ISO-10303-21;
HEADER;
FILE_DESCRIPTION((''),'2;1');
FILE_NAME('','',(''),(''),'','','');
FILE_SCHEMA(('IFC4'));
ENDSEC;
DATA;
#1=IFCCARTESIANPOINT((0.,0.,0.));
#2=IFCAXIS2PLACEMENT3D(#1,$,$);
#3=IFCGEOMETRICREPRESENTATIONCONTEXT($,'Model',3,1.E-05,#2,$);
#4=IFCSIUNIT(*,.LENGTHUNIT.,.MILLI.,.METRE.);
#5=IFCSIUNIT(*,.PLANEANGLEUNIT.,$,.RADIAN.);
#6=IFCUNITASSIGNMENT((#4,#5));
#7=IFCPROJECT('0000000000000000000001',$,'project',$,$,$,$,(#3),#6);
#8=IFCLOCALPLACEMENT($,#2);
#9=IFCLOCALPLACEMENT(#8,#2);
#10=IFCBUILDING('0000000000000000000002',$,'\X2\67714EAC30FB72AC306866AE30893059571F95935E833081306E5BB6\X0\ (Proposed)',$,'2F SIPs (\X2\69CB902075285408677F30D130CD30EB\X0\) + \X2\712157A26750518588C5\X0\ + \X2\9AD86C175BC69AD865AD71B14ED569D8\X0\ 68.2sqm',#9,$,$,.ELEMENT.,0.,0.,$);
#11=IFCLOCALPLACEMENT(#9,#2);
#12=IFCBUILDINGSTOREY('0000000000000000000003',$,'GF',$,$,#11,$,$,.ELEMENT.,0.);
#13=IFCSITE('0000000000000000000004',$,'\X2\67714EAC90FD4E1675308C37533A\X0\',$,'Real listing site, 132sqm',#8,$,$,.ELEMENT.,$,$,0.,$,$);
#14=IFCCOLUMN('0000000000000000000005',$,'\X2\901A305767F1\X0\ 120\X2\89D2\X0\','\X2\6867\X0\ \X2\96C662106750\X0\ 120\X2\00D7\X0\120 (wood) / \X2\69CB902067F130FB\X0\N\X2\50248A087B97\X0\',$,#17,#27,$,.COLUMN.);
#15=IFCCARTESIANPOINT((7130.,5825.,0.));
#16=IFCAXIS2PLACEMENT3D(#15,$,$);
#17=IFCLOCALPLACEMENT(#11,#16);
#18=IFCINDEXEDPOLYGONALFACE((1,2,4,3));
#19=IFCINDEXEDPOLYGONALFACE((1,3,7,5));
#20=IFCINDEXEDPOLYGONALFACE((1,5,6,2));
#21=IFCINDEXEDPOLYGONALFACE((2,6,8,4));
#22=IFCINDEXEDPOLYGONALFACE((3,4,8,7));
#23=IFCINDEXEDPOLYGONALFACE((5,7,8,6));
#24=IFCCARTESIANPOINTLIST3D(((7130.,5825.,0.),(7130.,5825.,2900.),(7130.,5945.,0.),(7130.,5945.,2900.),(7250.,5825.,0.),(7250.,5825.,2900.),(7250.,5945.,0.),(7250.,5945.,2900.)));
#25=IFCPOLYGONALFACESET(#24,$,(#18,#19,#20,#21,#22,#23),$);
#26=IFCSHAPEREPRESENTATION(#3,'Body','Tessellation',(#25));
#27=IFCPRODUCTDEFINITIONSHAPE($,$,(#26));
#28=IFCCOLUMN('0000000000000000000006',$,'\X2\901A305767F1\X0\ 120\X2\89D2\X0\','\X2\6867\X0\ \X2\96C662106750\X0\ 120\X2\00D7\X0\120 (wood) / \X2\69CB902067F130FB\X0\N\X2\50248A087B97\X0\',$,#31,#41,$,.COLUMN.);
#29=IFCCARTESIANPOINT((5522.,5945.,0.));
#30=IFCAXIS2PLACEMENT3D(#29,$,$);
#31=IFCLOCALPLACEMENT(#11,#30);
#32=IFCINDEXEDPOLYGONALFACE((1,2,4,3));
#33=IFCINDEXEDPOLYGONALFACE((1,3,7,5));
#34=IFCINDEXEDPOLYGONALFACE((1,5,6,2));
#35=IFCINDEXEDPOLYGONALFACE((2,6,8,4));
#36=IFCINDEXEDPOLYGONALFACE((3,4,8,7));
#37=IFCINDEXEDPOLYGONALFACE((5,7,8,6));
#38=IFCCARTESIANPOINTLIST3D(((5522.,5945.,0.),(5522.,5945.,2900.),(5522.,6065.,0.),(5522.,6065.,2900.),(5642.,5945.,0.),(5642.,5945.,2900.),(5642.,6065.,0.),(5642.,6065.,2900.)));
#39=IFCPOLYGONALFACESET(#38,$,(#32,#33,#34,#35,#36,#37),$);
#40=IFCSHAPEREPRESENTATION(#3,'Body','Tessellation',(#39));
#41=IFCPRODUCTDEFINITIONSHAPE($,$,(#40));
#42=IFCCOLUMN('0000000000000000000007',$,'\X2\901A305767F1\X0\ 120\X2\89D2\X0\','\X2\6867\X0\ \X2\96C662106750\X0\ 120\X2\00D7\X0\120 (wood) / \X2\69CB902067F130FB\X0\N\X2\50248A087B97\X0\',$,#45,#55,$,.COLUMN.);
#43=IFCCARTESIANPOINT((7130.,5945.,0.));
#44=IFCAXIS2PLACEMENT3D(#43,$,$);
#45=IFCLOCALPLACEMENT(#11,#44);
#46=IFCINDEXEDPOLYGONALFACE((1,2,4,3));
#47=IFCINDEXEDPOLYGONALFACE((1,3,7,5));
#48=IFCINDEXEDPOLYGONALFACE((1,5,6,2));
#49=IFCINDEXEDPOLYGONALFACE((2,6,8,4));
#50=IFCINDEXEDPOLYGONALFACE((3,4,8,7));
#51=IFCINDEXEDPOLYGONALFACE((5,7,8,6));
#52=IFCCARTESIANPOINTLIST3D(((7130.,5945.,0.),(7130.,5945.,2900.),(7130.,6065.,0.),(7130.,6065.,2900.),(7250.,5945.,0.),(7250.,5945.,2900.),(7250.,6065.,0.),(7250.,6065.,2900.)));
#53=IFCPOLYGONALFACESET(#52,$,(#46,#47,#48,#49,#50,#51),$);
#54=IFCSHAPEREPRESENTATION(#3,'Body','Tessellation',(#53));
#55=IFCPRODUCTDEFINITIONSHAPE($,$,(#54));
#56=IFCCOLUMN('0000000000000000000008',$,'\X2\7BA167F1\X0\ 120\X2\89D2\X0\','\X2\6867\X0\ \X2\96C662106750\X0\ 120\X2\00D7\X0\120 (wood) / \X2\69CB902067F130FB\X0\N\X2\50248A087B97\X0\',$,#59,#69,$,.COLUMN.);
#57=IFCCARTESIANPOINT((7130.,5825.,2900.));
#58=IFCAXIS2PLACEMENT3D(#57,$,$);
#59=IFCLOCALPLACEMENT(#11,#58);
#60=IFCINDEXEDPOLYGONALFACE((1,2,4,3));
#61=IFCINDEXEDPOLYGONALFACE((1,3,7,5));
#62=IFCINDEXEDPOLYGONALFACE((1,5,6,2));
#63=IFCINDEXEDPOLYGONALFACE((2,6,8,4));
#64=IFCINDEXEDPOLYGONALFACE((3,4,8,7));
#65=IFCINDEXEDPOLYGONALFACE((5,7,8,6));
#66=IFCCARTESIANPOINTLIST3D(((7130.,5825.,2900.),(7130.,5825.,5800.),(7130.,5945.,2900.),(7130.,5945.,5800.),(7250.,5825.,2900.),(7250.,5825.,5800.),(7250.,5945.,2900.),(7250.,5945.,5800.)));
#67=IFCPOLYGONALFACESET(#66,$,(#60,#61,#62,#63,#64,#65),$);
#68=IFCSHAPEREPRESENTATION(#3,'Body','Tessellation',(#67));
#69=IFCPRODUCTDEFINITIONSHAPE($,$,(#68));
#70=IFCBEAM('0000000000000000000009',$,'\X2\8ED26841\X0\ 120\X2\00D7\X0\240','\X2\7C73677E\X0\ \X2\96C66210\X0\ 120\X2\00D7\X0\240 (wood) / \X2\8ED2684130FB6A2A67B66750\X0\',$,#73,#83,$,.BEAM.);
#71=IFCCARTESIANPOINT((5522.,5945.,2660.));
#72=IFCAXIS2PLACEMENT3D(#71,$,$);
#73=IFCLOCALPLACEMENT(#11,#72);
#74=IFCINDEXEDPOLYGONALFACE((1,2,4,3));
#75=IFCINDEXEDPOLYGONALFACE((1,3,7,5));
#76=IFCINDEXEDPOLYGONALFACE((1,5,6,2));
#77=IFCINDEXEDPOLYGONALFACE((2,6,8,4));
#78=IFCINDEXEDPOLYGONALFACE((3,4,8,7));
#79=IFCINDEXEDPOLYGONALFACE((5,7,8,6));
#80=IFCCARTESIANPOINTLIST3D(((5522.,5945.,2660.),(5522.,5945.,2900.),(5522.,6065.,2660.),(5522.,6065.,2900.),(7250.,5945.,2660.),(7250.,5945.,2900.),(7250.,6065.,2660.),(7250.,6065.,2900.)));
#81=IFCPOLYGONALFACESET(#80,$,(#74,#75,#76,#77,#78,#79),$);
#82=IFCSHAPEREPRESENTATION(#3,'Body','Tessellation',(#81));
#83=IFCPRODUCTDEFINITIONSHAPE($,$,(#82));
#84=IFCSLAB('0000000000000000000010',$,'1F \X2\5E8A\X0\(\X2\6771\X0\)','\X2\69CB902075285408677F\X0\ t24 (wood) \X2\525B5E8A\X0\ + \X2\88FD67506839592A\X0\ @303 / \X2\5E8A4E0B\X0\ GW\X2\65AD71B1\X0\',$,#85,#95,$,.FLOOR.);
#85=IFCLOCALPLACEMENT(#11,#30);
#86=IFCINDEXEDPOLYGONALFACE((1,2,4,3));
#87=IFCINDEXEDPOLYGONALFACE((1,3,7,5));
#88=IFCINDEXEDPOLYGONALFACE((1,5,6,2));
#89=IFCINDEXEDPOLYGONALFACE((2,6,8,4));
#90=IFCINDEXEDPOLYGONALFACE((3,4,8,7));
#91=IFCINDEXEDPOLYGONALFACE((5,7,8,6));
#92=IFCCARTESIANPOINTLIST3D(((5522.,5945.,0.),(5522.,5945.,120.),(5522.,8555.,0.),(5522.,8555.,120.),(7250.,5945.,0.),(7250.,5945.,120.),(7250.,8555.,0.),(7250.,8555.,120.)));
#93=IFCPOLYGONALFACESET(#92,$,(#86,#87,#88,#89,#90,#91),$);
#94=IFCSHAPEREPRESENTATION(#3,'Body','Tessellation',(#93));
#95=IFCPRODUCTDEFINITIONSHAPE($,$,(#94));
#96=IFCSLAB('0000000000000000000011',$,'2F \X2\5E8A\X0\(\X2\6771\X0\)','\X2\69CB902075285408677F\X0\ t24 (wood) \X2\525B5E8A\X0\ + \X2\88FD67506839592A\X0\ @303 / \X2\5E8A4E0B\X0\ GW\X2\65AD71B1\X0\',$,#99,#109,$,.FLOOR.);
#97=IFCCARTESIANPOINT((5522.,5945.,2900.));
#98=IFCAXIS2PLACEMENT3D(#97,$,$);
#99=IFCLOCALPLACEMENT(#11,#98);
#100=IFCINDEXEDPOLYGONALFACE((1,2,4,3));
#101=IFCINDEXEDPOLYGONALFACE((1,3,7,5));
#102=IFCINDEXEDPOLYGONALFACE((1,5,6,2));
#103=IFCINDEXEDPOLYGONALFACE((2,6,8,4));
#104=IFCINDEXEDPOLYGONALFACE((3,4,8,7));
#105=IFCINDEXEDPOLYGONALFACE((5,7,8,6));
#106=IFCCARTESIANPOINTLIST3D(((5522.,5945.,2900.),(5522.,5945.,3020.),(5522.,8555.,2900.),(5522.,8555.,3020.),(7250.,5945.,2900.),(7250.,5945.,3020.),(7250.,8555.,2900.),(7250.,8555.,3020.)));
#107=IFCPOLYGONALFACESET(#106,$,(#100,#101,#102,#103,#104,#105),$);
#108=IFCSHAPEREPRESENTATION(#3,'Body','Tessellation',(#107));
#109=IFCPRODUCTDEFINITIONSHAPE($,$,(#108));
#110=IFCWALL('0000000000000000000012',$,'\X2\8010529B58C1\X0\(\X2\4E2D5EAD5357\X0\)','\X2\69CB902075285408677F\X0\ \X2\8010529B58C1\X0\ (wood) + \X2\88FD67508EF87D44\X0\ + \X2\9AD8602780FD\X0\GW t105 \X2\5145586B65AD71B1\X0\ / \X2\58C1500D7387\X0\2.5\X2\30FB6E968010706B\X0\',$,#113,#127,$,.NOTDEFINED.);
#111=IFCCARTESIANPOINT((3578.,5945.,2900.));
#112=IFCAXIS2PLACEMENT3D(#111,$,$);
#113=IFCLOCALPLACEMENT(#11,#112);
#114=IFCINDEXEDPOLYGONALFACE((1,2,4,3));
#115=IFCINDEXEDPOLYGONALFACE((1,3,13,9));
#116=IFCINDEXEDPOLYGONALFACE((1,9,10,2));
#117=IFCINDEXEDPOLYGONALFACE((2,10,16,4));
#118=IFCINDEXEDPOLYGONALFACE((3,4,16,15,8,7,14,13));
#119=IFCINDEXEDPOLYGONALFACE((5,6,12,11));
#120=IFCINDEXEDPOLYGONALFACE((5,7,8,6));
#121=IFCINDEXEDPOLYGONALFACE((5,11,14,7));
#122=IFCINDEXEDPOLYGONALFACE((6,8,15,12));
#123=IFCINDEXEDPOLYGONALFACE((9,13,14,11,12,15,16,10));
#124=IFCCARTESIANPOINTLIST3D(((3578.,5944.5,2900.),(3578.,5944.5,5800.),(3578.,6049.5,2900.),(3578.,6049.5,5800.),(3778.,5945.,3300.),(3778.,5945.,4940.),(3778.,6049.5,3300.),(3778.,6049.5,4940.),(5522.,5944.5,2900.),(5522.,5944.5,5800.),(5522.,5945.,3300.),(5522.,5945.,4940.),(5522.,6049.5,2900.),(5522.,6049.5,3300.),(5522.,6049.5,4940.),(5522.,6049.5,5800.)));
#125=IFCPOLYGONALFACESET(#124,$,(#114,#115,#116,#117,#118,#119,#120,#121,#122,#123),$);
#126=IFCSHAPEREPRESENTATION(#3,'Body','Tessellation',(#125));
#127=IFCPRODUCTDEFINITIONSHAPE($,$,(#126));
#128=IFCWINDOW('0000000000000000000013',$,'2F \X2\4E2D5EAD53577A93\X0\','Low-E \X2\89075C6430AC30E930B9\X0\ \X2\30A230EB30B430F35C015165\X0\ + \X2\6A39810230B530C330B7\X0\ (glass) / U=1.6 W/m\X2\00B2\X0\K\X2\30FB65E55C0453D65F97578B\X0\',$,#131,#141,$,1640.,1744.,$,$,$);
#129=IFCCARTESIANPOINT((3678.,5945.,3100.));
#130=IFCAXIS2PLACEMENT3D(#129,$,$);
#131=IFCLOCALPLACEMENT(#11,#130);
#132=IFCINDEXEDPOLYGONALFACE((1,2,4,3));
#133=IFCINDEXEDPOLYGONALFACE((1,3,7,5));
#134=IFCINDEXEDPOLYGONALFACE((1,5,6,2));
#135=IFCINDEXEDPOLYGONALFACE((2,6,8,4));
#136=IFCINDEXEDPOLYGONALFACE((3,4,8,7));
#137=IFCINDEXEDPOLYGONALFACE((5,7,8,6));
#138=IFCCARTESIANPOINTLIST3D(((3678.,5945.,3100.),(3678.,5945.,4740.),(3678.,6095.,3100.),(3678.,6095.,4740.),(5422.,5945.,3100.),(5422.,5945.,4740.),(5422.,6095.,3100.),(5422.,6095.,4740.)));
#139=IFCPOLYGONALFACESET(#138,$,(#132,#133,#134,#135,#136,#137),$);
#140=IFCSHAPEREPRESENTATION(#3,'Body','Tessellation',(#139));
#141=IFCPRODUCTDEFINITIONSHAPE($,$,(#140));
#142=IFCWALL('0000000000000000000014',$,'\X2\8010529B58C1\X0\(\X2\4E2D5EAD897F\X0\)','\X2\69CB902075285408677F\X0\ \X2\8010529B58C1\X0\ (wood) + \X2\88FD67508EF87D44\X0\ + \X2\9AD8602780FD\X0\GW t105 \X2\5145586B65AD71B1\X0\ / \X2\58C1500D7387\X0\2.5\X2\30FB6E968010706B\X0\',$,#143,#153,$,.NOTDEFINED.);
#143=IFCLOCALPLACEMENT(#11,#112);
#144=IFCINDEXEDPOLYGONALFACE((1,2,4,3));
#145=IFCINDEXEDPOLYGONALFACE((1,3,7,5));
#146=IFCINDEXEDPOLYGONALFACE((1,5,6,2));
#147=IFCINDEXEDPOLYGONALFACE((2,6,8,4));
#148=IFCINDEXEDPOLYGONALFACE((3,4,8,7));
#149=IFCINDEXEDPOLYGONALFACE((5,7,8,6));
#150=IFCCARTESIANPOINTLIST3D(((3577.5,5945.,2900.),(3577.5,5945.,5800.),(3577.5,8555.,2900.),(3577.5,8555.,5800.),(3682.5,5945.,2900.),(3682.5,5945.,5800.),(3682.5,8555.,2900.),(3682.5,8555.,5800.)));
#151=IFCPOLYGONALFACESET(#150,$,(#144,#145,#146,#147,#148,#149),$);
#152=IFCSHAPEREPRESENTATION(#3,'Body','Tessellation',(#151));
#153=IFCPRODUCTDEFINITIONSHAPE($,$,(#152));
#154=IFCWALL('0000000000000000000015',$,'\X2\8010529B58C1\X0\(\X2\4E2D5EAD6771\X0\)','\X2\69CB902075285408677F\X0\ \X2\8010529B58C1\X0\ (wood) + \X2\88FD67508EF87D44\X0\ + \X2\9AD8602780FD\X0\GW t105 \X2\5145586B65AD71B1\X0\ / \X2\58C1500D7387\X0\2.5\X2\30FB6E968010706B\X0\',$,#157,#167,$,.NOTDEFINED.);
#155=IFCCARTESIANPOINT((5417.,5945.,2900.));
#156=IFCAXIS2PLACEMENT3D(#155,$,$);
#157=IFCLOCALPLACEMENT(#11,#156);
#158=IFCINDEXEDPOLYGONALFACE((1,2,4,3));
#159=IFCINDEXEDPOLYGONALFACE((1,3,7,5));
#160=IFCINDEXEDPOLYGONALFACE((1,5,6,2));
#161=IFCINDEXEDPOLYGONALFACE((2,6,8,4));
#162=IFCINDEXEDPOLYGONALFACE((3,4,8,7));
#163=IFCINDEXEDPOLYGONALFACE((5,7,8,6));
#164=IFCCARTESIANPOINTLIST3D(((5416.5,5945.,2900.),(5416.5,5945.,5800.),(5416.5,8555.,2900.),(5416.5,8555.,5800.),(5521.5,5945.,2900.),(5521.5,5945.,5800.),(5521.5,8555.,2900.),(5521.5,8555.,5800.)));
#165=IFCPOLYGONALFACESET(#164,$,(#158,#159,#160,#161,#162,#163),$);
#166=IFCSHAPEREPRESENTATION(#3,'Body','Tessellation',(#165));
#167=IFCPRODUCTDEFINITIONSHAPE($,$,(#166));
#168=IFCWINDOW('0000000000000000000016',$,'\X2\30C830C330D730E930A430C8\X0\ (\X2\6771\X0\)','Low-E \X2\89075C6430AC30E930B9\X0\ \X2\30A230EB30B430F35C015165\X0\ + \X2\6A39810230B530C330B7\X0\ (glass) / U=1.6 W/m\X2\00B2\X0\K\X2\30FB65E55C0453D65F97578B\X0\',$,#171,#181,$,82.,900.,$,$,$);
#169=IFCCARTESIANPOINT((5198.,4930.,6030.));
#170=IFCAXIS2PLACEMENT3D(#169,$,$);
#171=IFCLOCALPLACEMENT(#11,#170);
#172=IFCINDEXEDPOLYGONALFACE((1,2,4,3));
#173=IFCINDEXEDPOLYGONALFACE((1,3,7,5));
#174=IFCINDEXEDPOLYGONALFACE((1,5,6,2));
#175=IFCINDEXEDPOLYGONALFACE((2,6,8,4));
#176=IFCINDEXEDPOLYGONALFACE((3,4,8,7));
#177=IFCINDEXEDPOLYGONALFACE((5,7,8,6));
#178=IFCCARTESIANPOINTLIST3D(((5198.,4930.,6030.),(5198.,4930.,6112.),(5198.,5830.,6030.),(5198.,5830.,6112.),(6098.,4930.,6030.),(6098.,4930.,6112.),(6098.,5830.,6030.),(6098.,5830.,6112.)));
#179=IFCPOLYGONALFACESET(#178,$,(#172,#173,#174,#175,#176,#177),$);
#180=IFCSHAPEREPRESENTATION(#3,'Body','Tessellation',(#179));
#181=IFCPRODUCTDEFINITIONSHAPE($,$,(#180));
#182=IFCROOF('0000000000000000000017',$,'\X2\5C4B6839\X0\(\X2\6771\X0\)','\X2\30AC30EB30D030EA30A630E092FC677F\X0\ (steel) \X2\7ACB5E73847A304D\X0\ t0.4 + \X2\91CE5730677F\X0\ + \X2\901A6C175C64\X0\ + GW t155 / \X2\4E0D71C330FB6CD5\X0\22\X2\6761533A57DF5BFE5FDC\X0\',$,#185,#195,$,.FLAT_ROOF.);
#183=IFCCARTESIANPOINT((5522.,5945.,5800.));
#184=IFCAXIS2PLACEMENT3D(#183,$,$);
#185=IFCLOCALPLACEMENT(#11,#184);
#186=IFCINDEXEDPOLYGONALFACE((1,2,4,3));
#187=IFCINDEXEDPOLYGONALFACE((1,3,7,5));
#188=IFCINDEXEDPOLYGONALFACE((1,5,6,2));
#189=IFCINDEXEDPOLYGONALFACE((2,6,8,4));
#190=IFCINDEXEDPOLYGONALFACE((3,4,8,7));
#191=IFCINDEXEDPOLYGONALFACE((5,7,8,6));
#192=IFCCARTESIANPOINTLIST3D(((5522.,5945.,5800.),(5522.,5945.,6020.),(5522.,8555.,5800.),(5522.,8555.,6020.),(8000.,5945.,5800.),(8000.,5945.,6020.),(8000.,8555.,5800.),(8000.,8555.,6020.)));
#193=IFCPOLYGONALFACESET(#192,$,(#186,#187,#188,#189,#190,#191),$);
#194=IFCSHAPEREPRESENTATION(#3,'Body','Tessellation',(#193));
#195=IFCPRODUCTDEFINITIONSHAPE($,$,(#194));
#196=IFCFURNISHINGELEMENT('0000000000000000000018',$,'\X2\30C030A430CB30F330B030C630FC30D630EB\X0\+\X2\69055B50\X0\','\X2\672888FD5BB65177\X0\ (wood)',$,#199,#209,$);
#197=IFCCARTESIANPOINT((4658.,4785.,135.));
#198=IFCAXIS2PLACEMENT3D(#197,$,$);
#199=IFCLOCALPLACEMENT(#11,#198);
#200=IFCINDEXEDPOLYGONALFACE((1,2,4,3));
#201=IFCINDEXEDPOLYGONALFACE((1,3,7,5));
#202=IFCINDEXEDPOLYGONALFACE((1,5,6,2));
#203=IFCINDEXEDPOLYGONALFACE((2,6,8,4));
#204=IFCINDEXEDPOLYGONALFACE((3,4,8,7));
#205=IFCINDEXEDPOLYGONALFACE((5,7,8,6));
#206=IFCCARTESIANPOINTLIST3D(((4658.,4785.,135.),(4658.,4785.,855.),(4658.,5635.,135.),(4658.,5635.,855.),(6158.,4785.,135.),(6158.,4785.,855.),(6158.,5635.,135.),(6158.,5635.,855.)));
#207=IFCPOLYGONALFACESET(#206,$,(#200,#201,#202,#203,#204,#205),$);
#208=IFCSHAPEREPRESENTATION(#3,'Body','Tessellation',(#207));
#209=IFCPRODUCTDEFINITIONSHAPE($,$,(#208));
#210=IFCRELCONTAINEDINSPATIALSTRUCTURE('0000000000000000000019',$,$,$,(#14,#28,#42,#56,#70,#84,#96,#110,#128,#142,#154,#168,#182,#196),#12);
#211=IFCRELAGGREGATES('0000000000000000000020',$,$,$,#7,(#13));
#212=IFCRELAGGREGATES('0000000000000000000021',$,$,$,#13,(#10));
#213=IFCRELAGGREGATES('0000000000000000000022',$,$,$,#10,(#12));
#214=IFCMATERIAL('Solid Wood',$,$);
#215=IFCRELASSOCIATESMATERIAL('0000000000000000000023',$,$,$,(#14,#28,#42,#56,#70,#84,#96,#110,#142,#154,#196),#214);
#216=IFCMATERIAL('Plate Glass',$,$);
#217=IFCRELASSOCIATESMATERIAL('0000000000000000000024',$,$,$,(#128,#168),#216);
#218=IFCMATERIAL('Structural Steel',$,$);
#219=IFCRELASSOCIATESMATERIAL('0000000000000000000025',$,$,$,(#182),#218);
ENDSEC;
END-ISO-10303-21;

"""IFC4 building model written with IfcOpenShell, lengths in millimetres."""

from ifc_helpers import new_model, si_unit, frame, frame_2d, origin, place, context, project, spatial, rectangle, extrude, material, element, fill, save


model = new_model("IFC4")

# Units and contexts
model_context = context("Model", 3, precision=1e-05, world=origin())
ifc_project = project(units=[si_unit("LENGTHUNIT", "METRE", prefix="MILLI"), si_unit("PLANEANGLEUNIT", "RADIAN")], contexts=[model_context])

# Site, building, storey
site_placement = place(None, origin())
site = spatial("IfcSite", under=ifc_project, at=site_placement, Name="東京都世田谷区", ObjectType="Real listing site, 132sqm", CompositionType="ELEMENT", RefElevation=0.0)
building_placement = place(site_placement, origin())
building = spatial("IfcBuilding", under=site, at=building_placement, Name="東京・犬と暮らす土間広めの家 (Proposed)", ObjectType="2F SIPs (構造用合板パネル) + 無垢材内装 + 高気密高断熱仕様 68.2sqm", CompositionType="ELEMENT", ElevationOfRefHeight=0.0, ElevationOfTerrain=0.0)
storey_placement = place(building_placement, origin())
storey = spatial("IfcBuildingStorey", under=building, at=storey_placement, Name="GF", CompositionType="ELEMENT", Elevation=0.0)

# Columns
ifc_material_1 = material(Name="Solid Wood")
column_1_placement = place(storey_placement, frame((7130.0, 5825.0, 0.0)))
element("IfcColumn", 1, at=column_1_placement, inside=storey, material=ifc_material_1, Name="通し柱 120角", Description="桧 集成材 120×120 (wood) / 構造柱・N値計算", PredefinedType="COLUMN", context=model_context, shape_type="SweptSolid", body=[
    extrude(rectangle(XDim=120.0, YDim=120.0, at=frame_2d((60.0, 60.0))), frame((7130.0, 5825.0, 0.0)), (0.0, 0.0, 1.0), 2900.0),
])
column_2_placement = place(storey_placement, frame((5522.0, 5945.0, 0.0)))
element("IfcColumn", 2, at=column_2_placement, inside=storey, material=ifc_material_1, Name="通し柱 120角", Description="桧 集成材 120×120 (wood) / 構造柱・N値計算", PredefinedType="COLUMN", context=model_context, shape_type="SweptSolid", body=[
    extrude(rectangle(XDim=120.0, YDim=120.0, at=frame_2d((60.0, 60.0))), frame((5522.0, 5945.0, 0.0)), (0.0, 0.0, 1.0), 2900.0),
])
column_3_placement = place(storey_placement, frame((7130.0, 5945.0, 0.0)))
element("IfcColumn", 3, at=column_3_placement, inside=storey, material=ifc_material_1, Name="通し柱 120角", Description="桧 集成材 120×120 (wood) / 構造柱・N値計算", PredefinedType="COLUMN", context=model_context, shape_type="SweptSolid", body=[
    extrude(rectangle(XDim=120.0, YDim=120.0, at=frame_2d((60.0, 60.0))), frame((7130.0, 5945.0, 0.0)), (0.0, 0.0, 1.0), 2900.0),
])
column_4_placement = place(storey_placement, frame((7130.0, 5825.0, 2900.0)))
element("IfcColumn", 4, at=column_4_placement, inside=storey, material=ifc_material_1, Name="管柱 120角", Description="桧 集成材 120×120 (wood) / 構造柱・N値計算", PredefinedType="COLUMN", context=model_context, shape_type="SweptSolid", body=[
    extrude(rectangle(XDim=120.0, YDim=120.0, at=frame_2d((60.0, 60.0))), frame((7130.0, 5825.0, 2900.0)), (0.0, 0.0, 1.0), 2900.0),
])

# Beam
beam_1_placement = place(storey_placement, frame((5522.0, 5945.0, 2660.0)))
element("IfcBeam", 5, at=beam_1_placement, inside=storey, material=ifc_material_1, Name="軒桁 120×240", Description="米松 集成 120×240 (wood) / 軒桁・横架材", PredefinedType="BEAM", context=model_context, shape_type="SweptSolid", body=[
    extrude(rectangle(XDim=1728.0, YDim=120.0, at=frame_2d((864.0, 60.0))), frame((5522.0, 5945.0, 2660.0)), (0.0, 0.0, 1.0), 240.0),
])

# Slabs
slab_1_placement = place(storey_placement, frame((5522.0, 5945.0, 0.0)))
element("IfcSlab", 6, at=slab_1_placement, inside=storey, material=ifc_material_1, Name="1F 床(東)", Description="構造用合板 t24 (wood) 剛床 + 製材根太 @303 / 床下 GW断熱", PredefinedType="FLOOR", context=model_context, shape_type="SweptSolid", body=[
    extrude(rectangle(XDim=1728.0, YDim=2610.0, at=frame_2d((864.0, 1305.0))), frame((5522.0, 5945.0, 0.0)), (0.0, 0.0, 1.0), 120.0),
])
slab_2_placement = place(storey_placement, frame((5522.0, 5945.0, 2900.0)))
element("IfcSlab", 7, at=slab_2_placement, inside=storey, material=ifc_material_1, Name="2F 床(東)", Description="構造用合板 t24 (wood) 剛床 + 製材根太 @303 / 床下 GW断熱", PredefinedType="FLOOR", context=model_context, shape_type="SweptSolid", body=[
    extrude(rectangle(XDim=1728.0, YDim=2610.0, at=frame_2d((864.0, 1305.0))), frame((5522.0, 5945.0, 2900.0)), (0.0, 0.0, 1.0), 120.0),
])

# Wall, opening, window
wall_1_placement = place(storey_placement, frame((3578.0, 5945.0, 2900.0)))
wall_1 = element("IfcWall", 8, at=wall_1_placement, inside=storey, material=ifc_material_1, Name="耐力壁(中庭南)", Description="構造用合板 耐力壁 (wood) + 製材軸組 + 高性能GW t105 充填断熱 / 壁倍率2.5・準耐火", PredefinedType="NOTDEFINED", context=model_context, shape_type="SweptSolid", body=[
    extrude(rectangle(XDim=1944.0, YDim=105.0, at=frame_2d((972.0, 52.0))), frame((3578.0, 5945.0, 2900.0)), (0.0, 0.0, 1.0), 2900.0),
])
opening_placement = place(storey_placement, frame((3678.0, 5945.0, 3100.0)))
opening = element("IfcOpeningElement", 9, at=opening_placement, cuts=wall_1, PredefinedType="NOTDEFINED", context=model_context, shape_type="SweptSolid", body=[
    extrude(rectangle(XDim=1744.0, YDim=150.0, at=frame_2d((872.0, 75.0))), frame((3678.0, 5945.0, 3100.0)), (0.0, 0.0, 1.0), 1640.0),
])
ifc_material_2 = material(Name="Plate Glass")
window_1_placement = place(storey_placement, frame((3678.0, 5945.0, 3100.0)))
window_1 = element("IfcWindow", 10, at=window_1_placement, inside=storey, material=ifc_material_2, Name="2F 中庭南窓", Description="Low-E 複層ガラス アルゴン封入 + 樹脂サッシ (glass) / U=1.6 W/m²K・日射取得型", OverallHeight=1640.0, OverallWidth=1744.0, context=model_context, shape_type="SweptSolid", body=[
    extrude(rectangle(XDim=1744.0, YDim=150.0, at=frame_2d((872.0, 75.0))), frame((3678.0, 5945.0, 3100.0)), (0.0, 0.0, 1.0), 1640.0),
])
fill(opening, window_1)

# Walls
wall_2_placement = place(storey_placement, frame((3578.0, 5945.0, 2900.0)))
element("IfcWall", 11, at=wall_2_placement, inside=storey, material=ifc_material_1, Name="耐力壁(中庭西)", Description="構造用合板 耐力壁 (wood) + 製材軸組 + 高性能GW t105 充填断熱 / 壁倍率2.5・準耐火", PredefinedType="NOTDEFINED", context=model_context, shape_type="SweptSolid", body=[
    extrude(rectangle(XDim=105.0, YDim=2610.0, at=frame_2d((52.0, 1305.0))), frame((3578.0, 5945.0, 2900.0)), (0.0, 0.0, 1.0), 2900.0),
])
wall_3_placement = place(storey_placement, frame((5417.0, 5945.0, 2900.0)))
element("IfcWall", 12, at=wall_3_placement, inside=storey, material=ifc_material_1, Name="耐力壁(中庭東)", Description="構造用合板 耐力壁 (wood) + 製材軸組 + 高性能GW t105 充填断熱 / 壁倍率2.5・準耐火", PredefinedType="NOTDEFINED", context=model_context, shape_type="SweptSolid", body=[
    extrude(rectangle(XDim=105.0, YDim=2610.0, at=frame_2d((52.0, 1305.0))), frame((5417.0, 5945.0, 2900.0)), (0.0, 0.0, 1.0), 2900.0),
])

# Window
window_2_placement = place(storey_placement, frame((5198.0, 4930.0, 6030.0)))
element("IfcWindow", 13, at=window_2_placement, inside=storey, material=ifc_material_2, Name="トップライト (東)", Description="Low-E 複層ガラス アルゴン封入 + 樹脂サッシ (glass) / U=1.6 W/m²K・日射取得型", OverallHeight=82.0, OverallWidth=900.0, context=model_context, shape_type="SweptSolid", body=[
    extrude(rectangle(XDim=900.0, YDim=900.0, at=frame_2d((450.0, 450.0))), frame((5198.0, 4930.0, 6030.0)), (0.0, 0.0, 1.0), 82.0),
])

# Roof
ifc_material_3 = material(Name="Structural Steel")
for number, where, name in (
    (14, (5522.0, 5945.0, 5800.0), "屋根(東)"),
):
    element("IfcRoof", number, at=place(storey_placement, frame(where)), inside=storey, material=ifc_material_3, Name=name, Description="ガルバリウム鋼板 (steel) 立平葺き t0.4 + 野地板 + 通気層 + GW t155 / 不燃・法22条区域対応", PredefinedType="FLAT_ROOF", context=model_context, shape_type="SweptSolid", body=[
        extrude(rectangle(XDim=2478.0, YDim=2610.0, at=frame_2d((1239.0, 1305.0))), frame((5522.0, 5945.0, 5800.0)), (0.0, 0.0, 1.0), 220.0),
    ])

# Furnishing element
furnishing_1_placement = place(storey_placement, frame((4658.0, 4785.0, 135.0)))
element("IfcFurnishingElement", 15, at=furnishing_1_placement, inside=storey, material=ifc_material_1, Name="ダイニングテーブル+椅子", Description="木製家具 (wood)", context=model_context, shape_type="SweptSolid", body=[
    extrude(rectangle(XDim=1500.0, YDim=850.0, at=frame_2d((750.0, 425.0))), frame((4658.0, 4785.0, 135.0)), (0.0, 0.0, 1.0), 720.0),
])

save(model, "model.ifc")
